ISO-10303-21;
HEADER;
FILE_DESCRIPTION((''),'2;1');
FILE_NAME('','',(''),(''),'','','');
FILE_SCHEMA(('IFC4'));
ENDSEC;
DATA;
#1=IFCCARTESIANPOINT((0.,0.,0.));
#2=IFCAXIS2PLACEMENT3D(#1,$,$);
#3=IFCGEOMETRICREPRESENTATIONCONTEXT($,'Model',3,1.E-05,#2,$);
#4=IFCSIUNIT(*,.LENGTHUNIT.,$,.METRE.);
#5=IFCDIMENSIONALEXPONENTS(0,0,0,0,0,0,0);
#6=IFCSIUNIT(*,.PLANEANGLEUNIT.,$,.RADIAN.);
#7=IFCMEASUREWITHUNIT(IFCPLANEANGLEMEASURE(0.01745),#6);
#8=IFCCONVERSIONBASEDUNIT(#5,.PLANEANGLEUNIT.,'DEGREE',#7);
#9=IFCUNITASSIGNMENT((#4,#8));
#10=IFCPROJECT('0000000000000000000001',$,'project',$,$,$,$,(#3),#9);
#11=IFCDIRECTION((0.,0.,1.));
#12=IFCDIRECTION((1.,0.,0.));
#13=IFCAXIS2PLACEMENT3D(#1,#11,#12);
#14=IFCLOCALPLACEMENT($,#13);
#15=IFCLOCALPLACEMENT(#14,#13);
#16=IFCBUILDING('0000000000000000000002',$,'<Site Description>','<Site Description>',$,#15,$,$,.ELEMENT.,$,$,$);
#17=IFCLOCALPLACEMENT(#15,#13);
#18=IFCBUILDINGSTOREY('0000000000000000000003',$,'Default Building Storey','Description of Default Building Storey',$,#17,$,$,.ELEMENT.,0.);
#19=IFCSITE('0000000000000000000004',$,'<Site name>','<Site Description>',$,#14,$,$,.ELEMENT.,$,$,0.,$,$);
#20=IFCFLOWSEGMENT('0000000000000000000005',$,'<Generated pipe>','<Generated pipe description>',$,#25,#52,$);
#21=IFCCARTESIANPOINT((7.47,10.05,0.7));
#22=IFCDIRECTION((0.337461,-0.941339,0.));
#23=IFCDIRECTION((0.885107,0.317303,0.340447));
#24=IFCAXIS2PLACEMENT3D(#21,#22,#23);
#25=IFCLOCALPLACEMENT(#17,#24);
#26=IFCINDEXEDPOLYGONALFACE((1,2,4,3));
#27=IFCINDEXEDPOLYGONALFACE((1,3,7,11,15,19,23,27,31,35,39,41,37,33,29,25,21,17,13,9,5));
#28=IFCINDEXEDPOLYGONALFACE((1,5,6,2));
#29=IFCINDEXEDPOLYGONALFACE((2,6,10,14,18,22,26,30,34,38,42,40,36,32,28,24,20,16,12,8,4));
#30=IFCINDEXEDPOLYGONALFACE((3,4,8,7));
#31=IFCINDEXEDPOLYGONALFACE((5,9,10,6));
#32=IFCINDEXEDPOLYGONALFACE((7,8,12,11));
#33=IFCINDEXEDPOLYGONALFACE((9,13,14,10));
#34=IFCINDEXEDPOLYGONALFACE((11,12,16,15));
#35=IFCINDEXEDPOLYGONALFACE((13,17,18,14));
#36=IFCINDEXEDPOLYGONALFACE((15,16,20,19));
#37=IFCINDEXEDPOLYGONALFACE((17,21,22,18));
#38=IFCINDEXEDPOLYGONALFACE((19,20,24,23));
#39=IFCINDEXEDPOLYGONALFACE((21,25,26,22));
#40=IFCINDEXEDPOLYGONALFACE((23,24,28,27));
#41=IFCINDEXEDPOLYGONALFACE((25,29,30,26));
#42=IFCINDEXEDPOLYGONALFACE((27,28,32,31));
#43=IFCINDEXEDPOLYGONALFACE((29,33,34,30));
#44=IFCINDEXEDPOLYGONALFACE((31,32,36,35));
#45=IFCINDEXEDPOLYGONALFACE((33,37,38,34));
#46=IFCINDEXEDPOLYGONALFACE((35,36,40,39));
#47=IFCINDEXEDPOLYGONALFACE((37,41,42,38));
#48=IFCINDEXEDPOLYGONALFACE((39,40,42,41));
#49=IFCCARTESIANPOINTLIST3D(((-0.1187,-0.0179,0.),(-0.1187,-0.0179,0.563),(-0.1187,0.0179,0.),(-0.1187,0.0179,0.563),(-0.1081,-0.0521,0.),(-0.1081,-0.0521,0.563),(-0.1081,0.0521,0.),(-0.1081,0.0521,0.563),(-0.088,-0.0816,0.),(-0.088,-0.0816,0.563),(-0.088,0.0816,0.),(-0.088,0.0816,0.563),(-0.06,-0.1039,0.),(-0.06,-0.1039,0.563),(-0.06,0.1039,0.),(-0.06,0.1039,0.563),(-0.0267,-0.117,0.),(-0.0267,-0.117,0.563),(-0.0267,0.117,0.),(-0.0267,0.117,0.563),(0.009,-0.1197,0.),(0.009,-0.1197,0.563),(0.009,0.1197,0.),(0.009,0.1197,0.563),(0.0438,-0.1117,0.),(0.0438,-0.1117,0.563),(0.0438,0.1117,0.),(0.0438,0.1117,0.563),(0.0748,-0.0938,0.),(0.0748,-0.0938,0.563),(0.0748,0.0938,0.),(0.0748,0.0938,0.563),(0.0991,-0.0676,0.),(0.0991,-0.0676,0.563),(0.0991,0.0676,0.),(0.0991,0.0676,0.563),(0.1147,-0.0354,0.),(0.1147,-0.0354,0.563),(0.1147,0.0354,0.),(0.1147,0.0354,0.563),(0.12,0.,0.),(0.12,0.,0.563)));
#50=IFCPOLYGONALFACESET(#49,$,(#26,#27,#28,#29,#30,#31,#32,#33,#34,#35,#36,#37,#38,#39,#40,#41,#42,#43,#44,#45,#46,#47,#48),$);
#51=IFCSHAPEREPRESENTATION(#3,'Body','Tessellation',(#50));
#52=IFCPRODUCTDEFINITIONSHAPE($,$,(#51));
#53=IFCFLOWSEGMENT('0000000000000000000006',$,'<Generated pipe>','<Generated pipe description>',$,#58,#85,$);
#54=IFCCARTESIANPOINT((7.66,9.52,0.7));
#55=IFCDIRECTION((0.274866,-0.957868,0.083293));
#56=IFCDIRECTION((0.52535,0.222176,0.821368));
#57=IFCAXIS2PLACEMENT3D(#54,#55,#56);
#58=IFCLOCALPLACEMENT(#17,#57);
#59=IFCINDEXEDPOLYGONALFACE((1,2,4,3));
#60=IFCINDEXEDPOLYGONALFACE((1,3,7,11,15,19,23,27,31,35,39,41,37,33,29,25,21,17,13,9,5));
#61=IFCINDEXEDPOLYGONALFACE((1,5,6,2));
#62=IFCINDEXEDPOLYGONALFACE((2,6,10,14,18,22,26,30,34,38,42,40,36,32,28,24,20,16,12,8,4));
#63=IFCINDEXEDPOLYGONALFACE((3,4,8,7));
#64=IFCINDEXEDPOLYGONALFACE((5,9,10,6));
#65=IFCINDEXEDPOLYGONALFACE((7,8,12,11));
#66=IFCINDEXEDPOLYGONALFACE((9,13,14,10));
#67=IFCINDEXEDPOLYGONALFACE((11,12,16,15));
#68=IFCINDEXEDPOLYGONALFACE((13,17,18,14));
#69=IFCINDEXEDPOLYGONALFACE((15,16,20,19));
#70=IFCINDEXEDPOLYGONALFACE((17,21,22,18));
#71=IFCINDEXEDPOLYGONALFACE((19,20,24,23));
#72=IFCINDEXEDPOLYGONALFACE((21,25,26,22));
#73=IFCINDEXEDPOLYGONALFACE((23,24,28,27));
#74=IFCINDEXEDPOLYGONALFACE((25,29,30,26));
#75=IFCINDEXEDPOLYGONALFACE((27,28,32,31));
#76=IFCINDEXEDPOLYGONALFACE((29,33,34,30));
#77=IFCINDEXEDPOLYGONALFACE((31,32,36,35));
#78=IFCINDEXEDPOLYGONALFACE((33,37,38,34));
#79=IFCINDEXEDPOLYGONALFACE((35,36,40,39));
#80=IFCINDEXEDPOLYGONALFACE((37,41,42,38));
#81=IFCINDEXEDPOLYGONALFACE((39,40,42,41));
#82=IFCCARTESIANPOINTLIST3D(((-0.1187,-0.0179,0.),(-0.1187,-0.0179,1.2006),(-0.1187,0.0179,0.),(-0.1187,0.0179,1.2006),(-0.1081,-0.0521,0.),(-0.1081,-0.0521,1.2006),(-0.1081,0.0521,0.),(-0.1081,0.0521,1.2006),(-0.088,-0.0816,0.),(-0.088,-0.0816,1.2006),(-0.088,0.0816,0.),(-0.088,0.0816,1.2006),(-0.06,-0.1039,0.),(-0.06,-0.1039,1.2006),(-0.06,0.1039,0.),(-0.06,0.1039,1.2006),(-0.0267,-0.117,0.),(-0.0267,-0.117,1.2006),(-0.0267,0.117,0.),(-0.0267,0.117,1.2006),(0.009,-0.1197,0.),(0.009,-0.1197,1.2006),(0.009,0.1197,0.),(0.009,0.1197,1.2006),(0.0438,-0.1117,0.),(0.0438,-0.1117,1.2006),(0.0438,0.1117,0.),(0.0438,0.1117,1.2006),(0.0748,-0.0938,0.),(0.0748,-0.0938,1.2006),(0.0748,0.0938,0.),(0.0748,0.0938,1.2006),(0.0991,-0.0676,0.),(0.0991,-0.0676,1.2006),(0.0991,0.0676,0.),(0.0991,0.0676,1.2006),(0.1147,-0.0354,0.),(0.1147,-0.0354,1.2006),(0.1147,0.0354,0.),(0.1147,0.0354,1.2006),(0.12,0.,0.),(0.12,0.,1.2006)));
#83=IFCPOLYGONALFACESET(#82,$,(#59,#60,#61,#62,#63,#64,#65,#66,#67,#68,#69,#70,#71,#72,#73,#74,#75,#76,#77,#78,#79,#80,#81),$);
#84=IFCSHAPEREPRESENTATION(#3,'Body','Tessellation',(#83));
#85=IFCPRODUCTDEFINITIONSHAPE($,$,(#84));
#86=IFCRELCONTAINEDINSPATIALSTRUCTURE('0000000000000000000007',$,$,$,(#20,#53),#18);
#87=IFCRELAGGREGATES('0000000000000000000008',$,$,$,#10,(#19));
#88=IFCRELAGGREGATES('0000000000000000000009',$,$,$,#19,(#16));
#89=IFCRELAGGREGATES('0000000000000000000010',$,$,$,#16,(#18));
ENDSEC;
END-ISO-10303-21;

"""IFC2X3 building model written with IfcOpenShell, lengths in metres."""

from ifc_helpers import new_model, entity, si_unit, converted_unit, frame, origin, origin_with_axes, origin_2d_with_axis, place, context, project, spatial, circle, extrude, element, save


model = new_model("IFC2X3")

# Units and contexts
model_context = context("Model", 3, precision=1e-05, world=origin())
ifc_project = project(units=[si_unit("LENGTHUNIT", "METRE"), converted_unit("PLANEANGLEUNIT", "DEGREE", entity("IfcPlaneAngleMeasure", 0.01745), si_unit("PLANEANGLEUNIT", "RADIAN"), dimensions=[0, 0, 0, 0, 0, 0, 0])], contexts=[model_context])

# Site, building, storey
site_placement = place(None, origin_with_axes())
site = spatial("IfcSite", under=ifc_project, at=site_placement, Name="<Site name>", Description="<Site Description>", CompositionType="ELEMENT", RefElevation=0.0)
building_placement = place(site_placement, origin_with_axes())
building = spatial("IfcBuilding", under=site, at=building_placement, Name="<Site Description>", Description="<Site Description>", CompositionType="ELEMENT")
storey_placement = place(building_placement, origin_with_axes())
storey = spatial("IfcBuildingStorey", under=building, at=storey_placement, Name="Default Building Storey", Description="Description of Default Building Storey", CompositionType="ELEMENT", Elevation=0.0)

# Flow segments
flow_segment_1_placement = place(storey_placement, frame((7.47, 10.05, 0.7), z_axis=(0.337461, -0.941339, 0.0), x_axis=(0.885107, 0.317303, 0.340447)))
element("IfcFlowSegment", 1, at=flow_segment_1_placement, inside=storey, Name="<Generated pipe>", Description="<Generated pipe description>", context=model_context, shape_type="SweptSolid", body=[
    extrude(circle(Radius=0.12, at=origin_2d_with_axis()), origin_with_axes(), (0.0, 0.0, 1.0), 0.563),
])
flow_segment_2_placement = place(storey_placement, frame((7.66, 9.52, 0.7), z_axis=(0.274866, -0.957868, 0.083293), x_axis=(0.52535, 0.222176, 0.821368)))
element("IfcFlowSegment", 2, at=flow_segment_2_placement, inside=storey, Name="<Generated pipe>", Description="<Generated pipe description>", context=model_context, shape_type="SweptSolid", body=[
    extrude(circle(Radius=0.12, at=origin_2d_with_axis()), origin_with_axes(), (0.0, 0.0, 1.0), 1.2006),
])

save(model, "model.ifc")
